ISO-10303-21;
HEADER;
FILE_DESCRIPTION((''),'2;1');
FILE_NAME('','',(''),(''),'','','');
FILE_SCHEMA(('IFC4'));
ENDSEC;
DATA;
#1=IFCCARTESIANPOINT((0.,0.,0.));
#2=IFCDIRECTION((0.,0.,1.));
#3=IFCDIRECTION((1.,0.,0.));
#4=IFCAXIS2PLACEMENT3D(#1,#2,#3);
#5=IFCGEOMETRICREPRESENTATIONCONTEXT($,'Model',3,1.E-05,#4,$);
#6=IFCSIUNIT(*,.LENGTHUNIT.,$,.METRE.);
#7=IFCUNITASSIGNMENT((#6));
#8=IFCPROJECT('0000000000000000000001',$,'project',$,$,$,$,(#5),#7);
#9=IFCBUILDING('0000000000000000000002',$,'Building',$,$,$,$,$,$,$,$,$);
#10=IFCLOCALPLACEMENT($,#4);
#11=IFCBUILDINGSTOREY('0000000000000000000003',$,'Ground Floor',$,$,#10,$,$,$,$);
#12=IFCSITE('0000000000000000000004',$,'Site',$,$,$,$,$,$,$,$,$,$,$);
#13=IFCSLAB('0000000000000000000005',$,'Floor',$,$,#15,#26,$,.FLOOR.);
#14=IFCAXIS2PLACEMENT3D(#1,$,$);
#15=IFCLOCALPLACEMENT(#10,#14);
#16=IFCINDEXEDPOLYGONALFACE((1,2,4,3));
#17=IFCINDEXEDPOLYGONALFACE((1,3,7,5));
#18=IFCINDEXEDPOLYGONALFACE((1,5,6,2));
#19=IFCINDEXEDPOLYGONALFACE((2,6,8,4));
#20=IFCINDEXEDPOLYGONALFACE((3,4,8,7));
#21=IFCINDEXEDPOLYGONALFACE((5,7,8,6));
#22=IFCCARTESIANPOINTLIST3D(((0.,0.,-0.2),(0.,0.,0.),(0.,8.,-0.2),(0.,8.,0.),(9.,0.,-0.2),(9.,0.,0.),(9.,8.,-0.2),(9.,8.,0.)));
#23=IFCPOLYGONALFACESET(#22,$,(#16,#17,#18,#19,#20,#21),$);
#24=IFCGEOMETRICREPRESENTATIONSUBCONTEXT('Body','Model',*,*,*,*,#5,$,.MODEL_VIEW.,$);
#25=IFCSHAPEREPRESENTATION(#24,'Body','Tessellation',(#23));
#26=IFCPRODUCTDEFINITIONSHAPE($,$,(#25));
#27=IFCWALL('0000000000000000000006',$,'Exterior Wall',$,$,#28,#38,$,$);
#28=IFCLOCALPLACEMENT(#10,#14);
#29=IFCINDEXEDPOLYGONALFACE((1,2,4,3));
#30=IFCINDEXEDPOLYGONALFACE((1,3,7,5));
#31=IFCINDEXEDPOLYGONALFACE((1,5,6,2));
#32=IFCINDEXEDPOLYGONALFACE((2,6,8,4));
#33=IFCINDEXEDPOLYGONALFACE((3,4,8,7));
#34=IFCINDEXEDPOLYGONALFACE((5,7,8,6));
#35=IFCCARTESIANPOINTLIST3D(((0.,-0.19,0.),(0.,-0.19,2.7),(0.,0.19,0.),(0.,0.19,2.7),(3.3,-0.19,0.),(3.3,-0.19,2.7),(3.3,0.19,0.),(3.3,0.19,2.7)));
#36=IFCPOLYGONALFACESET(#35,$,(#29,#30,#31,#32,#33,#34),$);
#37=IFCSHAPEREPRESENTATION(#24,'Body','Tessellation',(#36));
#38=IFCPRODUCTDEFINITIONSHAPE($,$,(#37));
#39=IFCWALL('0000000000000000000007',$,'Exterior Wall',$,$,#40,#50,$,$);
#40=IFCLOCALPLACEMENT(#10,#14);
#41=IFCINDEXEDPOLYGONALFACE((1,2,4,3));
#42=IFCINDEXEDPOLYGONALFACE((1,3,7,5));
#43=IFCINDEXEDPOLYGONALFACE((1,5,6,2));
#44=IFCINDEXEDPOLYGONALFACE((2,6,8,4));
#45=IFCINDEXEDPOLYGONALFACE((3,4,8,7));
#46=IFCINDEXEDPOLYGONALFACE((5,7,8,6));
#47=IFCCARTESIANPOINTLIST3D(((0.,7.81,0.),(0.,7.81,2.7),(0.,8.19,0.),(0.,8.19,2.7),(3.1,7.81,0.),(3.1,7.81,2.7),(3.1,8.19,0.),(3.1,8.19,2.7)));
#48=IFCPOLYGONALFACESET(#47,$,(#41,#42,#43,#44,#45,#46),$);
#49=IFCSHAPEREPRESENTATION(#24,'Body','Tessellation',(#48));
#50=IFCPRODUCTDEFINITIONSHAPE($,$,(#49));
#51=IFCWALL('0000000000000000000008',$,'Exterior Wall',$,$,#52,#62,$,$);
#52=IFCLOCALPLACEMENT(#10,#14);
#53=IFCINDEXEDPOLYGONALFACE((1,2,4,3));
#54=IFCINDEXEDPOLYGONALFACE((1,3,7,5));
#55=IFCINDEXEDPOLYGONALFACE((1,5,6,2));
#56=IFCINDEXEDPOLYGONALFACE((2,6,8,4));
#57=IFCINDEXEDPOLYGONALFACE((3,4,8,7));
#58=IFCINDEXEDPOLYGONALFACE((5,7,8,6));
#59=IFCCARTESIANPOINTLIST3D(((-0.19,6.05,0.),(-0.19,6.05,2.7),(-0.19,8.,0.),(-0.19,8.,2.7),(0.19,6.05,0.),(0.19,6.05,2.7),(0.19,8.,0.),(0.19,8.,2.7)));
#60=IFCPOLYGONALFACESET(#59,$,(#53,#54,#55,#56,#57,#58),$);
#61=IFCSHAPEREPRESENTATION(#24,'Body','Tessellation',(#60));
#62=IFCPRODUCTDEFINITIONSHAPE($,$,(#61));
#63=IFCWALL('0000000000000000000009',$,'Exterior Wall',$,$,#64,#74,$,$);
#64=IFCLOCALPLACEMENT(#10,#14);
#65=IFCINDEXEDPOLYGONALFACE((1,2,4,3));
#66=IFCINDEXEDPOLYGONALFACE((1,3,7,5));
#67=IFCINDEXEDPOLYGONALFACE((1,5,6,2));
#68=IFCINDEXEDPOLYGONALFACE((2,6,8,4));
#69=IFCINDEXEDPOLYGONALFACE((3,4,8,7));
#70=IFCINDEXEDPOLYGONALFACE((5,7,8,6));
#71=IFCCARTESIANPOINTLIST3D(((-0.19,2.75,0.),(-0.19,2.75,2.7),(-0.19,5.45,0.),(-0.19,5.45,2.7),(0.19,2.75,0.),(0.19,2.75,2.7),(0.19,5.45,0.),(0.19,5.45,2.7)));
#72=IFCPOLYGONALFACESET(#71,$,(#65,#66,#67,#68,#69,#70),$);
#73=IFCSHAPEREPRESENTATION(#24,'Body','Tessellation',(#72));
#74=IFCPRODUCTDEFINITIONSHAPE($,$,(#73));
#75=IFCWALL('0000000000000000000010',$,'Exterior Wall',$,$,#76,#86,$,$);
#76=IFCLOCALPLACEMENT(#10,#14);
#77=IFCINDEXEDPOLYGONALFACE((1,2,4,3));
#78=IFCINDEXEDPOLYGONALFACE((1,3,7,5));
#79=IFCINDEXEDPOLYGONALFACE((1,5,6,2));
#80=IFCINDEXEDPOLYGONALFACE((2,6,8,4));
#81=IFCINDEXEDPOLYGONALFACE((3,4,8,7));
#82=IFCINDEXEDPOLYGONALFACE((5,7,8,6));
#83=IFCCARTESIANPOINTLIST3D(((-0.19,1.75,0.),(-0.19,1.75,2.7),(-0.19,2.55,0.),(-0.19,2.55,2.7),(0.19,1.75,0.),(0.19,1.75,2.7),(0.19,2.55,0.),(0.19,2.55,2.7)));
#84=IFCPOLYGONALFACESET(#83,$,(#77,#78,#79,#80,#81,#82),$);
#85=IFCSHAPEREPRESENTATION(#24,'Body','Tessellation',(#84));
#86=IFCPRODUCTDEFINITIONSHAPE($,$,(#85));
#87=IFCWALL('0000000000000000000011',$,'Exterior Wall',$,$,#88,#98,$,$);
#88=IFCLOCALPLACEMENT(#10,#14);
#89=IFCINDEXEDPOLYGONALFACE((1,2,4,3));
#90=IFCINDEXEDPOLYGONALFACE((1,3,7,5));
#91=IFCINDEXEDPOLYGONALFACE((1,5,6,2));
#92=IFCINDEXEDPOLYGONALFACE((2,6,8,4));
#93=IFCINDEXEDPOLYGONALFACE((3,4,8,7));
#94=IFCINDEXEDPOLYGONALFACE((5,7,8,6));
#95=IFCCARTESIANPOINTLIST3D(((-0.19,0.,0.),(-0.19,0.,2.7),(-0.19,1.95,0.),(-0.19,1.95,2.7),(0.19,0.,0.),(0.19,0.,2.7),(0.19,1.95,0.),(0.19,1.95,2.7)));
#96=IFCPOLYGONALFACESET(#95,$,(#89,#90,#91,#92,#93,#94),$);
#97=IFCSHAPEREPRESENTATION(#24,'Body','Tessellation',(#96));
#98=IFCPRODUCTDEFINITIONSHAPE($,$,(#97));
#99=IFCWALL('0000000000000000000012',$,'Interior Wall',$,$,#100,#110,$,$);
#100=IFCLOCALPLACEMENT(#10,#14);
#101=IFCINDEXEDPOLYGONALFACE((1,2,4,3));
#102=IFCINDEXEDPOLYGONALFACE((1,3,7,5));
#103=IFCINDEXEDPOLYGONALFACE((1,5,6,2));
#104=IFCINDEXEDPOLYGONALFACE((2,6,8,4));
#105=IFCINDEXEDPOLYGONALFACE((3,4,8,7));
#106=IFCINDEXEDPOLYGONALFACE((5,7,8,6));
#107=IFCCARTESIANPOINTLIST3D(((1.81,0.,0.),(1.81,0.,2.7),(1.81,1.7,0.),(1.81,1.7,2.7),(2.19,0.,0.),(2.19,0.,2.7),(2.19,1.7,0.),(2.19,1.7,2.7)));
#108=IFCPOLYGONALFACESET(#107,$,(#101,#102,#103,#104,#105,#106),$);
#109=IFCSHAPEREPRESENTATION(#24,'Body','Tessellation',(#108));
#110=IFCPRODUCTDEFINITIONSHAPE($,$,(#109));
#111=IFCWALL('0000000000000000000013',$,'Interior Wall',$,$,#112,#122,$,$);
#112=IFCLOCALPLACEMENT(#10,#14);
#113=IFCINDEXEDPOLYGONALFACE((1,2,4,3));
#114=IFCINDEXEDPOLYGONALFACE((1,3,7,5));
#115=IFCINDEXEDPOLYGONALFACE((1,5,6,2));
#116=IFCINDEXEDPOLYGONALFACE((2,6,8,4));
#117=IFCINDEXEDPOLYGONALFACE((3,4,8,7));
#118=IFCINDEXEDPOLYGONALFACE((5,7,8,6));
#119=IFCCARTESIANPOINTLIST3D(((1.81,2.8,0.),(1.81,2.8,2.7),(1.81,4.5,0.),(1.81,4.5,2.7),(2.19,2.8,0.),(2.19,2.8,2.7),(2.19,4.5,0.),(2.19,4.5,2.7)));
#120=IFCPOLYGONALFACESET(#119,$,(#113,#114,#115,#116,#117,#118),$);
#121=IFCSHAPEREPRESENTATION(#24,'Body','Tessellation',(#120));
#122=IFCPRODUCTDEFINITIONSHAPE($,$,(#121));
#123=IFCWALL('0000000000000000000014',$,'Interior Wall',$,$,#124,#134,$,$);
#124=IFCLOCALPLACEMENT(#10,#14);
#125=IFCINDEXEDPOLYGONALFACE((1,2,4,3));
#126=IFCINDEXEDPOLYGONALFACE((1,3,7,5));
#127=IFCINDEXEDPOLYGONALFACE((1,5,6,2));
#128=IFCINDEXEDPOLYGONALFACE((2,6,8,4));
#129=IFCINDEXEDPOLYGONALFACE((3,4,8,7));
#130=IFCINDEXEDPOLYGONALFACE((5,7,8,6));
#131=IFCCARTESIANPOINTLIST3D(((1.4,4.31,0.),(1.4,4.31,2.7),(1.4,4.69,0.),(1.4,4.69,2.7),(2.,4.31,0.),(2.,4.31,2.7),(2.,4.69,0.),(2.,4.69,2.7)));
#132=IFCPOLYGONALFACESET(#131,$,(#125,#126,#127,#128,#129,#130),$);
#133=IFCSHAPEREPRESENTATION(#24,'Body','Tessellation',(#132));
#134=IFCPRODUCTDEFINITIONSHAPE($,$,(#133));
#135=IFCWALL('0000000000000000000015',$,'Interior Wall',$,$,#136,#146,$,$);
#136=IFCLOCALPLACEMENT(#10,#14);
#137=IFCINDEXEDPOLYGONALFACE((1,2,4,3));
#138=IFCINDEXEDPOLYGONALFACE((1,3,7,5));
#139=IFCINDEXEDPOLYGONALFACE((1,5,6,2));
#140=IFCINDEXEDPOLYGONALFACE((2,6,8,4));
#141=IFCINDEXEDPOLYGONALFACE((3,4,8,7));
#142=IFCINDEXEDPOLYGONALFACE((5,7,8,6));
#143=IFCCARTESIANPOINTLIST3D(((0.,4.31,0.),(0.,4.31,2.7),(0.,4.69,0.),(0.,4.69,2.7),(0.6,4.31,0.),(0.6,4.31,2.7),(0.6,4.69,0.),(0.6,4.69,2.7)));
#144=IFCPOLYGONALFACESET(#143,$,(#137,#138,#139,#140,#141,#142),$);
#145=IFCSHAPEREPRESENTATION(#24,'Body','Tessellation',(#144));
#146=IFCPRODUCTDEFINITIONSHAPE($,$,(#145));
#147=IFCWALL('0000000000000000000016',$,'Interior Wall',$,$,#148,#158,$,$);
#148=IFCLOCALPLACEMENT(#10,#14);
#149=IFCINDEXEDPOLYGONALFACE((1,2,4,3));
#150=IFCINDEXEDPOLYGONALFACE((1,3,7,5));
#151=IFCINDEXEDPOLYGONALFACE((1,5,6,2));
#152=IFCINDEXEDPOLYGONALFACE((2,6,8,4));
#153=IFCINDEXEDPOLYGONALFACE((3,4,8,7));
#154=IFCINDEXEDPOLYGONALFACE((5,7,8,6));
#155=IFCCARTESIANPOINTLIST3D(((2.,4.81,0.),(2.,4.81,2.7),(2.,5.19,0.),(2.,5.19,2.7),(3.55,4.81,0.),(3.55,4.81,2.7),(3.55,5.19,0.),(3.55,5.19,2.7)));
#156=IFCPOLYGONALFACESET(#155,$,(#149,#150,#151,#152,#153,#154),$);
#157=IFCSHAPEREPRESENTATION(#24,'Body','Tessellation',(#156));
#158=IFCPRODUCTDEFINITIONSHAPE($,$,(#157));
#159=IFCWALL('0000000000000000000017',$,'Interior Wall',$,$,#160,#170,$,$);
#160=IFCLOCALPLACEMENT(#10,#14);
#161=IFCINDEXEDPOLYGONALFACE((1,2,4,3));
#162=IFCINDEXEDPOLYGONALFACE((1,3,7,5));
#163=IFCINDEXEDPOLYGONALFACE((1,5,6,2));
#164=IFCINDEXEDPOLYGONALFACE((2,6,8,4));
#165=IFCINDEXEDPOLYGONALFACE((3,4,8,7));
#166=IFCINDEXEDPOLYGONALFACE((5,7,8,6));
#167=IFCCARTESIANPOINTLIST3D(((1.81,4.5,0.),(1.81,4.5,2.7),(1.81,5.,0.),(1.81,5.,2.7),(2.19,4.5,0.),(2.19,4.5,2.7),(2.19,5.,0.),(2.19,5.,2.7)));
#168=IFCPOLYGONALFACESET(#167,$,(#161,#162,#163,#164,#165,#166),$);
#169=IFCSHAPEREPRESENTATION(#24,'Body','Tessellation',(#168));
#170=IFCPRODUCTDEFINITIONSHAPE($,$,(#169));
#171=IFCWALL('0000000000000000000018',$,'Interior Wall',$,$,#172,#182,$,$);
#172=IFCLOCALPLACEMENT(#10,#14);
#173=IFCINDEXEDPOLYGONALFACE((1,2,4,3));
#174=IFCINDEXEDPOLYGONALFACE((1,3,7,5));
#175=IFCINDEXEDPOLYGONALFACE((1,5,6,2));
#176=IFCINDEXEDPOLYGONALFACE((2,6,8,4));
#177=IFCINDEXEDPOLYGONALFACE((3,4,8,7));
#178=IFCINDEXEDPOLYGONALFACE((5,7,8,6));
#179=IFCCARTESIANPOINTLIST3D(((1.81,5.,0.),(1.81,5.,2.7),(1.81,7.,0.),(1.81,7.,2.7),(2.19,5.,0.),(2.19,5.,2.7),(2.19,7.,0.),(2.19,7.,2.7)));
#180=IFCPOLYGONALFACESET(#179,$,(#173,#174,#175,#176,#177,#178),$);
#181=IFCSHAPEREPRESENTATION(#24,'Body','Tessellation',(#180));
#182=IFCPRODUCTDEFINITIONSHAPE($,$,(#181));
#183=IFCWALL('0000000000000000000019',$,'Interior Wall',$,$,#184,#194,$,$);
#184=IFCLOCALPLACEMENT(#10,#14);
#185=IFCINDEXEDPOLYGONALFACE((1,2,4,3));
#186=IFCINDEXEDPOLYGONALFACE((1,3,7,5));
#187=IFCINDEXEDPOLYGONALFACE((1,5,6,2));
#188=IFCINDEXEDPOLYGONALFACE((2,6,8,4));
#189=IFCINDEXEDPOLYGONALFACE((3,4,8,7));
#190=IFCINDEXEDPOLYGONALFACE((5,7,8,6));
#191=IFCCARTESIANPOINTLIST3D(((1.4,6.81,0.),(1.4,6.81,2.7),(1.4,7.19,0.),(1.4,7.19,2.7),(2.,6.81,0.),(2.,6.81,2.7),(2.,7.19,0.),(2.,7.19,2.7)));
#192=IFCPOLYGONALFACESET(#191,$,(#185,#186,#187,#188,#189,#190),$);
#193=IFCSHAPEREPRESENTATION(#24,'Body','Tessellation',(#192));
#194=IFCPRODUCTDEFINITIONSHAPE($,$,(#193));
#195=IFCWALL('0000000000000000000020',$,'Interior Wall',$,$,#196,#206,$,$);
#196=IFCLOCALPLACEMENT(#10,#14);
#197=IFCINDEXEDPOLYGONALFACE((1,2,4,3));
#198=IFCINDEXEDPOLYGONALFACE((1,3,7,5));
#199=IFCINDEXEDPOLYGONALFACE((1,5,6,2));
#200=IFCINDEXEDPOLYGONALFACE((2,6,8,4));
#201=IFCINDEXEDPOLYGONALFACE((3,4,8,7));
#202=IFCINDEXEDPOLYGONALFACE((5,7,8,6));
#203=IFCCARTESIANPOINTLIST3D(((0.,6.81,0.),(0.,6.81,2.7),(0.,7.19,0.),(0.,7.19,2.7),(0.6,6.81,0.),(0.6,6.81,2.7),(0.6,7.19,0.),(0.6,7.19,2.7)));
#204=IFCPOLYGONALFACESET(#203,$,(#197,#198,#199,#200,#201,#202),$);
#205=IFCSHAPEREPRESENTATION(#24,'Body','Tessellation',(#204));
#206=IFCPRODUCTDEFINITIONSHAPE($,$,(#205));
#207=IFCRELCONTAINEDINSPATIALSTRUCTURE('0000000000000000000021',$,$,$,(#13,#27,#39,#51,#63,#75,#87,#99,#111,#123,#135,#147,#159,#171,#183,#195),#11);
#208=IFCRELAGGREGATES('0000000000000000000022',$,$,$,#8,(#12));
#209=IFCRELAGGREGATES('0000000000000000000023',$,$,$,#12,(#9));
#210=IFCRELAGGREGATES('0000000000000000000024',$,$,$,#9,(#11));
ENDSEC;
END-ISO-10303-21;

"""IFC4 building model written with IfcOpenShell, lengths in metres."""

from ifc_helpers import new_model, si_unit, frame, origin_with_axes, place, context, subcontext, project, spatial, indexed_curve, outline, extrude, element, save


model = new_model("IFC4")

# Units and contexts
model_context = context("Model", 3, precision=1e-05, world=origin_with_axes())
body_context = subcontext(model_context, "Body", "Model", "MODEL_VIEW")
ifc_project = project(units=[si_unit("LENGTHUNIT", "METRE")], contexts=[model_context])

# Site, building, storey
site = spatial("IfcSite", under=ifc_project, Name="Site")
building = spatial("IfcBuilding", under=site, Name="Building")
storey_placement = place(None, origin_with_axes())
storey = spatial("IfcBuildingStorey", under=building, at=storey_placement, Name="Ground Floor")

# Slab
slab_placement = place(storey_placement, frame((0.0, 0.0, -0.2), z_axis=(0.0, 0.0, 1.0), x_axis=(1.0, 0.0, 0.0)))
element("IfcSlab", 1, at=slab_placement, inside=storey, Name="Floor", PredefinedType="FLOOR", context=body_context, shape_type="SweptSolid", body=[
    extrude(outline(indexed_curve([(0.0, 0.0), (9.0, 0.0), (9.0, 8.0), (0.0, 8.0)])), None, (0.0, 0.0, 1.0), 0.2),
])

# Walls
wall_1_placement = place(storey_placement, origin_with_axes())
element("IfcWall", 2, at=wall_1_placement, inside=storey, Name="Exterior Wall", context=body_context, shape_type="SweptSolid", body=[
    extrude(outline(indexed_curve([(0.0, 0.0), (0.0, 0.38), (3.3, 0.38), (3.3, 0.0), (0.0, 0.0)], self_intersect=False)), frame((0.0, -0.19, 0.0), z_axis=(0.0, 0.0, 1.0), x_axis=(1.0, 0.0, 0.0)), (0.0, 0.0, 1.0), 2.7),
])
wall_2_placement = place(storey_placement, frame((3.1, 8.0, 0.0), z_axis=(0.0, 0.0, 1.0), x_axis=(-1.0, 0.0, 0.0)))
element("IfcWall", 3, at=wall_2_placement, inside=storey, Name="Exterior Wall", context=body_context, shape_type="SweptSolid", body=[
    extrude(outline(indexed_curve([(0.0, 0.0), (0.0, 0.38), (3.1, 0.38), (3.1, 0.0), (0.0, 0.0)], self_intersect=False)), frame((0.0, -0.19, 0.0), z_axis=(0.0, 0.0, 1.0), x_axis=(1.0, 0.0, 0.0)), (0.0, 0.0, 1.0), 2.7),
])
wall_3_placement = place(storey_placement, frame((0.0, 8.0, 0.0), z_axis=(0.0, 0.0, 1.0), x_axis=(0.0, -1.0, 0.0)))
element("IfcWall", 4, at=wall_3_placement, inside=storey, Name="Exterior Wall", context=body_context, shape_type="SweptSolid", body=[
    extrude(outline(indexed_curve([(0.0, 0.0), (0.0, 0.38), (1.95, 0.38), (1.95, 0.0), (0.0, 0.0)], self_intersect=False)), frame((0.0, -0.19, 0.0), z_axis=(0.0, 0.0, 1.0), x_axis=(1.0, 0.0, 0.0)), (0.0, 0.0, 1.0), 2.7),
])
wall_4_placement = place(storey_placement, frame((0.0, 5.45, 0.0), z_axis=(0.0, 0.0, 1.0), x_axis=(0.0, -1.0, 0.0)))
element("IfcWall", 5, at=wall_4_placement, inside=storey, Name="Exterior Wall", context=body_context, shape_type="SweptSolid", body=[
    extrude(outline(indexed_curve([(0.0, 0.0), (0.0, 0.38), (2.7, 0.38), (2.7, 0.0), (0.0, 0.0)], self_intersect=False)), frame((0.0, -0.19, 0.0), z_axis=(0.0, 0.0, 1.0), x_axis=(1.0, 0.0, 0.0)), (0.0, 0.0, 1.0), 2.7),
])
wall_5_placement = place(storey_placement, frame((0.0, 1.75, 0.0), z_axis=(0.0, 0.0, 1.0), x_axis=(0.0, 1.0, 0.0)))
element("IfcWall", 6, at=wall_5_placement, inside=storey, Name="Exterior Wall", context=body_context, shape_type="SweptSolid", body=[
    extrude(outline(indexed_curve([(0.0, 0.0), (0.0, 0.38), (0.8, 0.38), (0.8, 0.0), (0.0, 0.0)], self_intersect=False)), frame((0.0, -0.19, 0.0), z_axis=(0.0, 0.0, 1.0), x_axis=(1.0, 0.0, 0.0)), (0.0, 0.0, 1.0), 2.7),
])
wall_6_placement = place(storey_placement, frame((0.0, 1.95, 0.0), z_axis=(0.0, 0.0, 1.0), x_axis=(0.0, -1.0, 0.0)))
element("IfcWall", 7, at=wall_6_placement, inside=storey, Name="Exterior Wall", context=body_context, shape_type="SweptSolid", body=[
    extrude(outline(indexed_curve([(0.0, 0.0), (0.0, 0.38), (1.95, 0.38), (1.95, 0.0), (0.0, 0.0)], self_intersect=False)), frame((0.0, -0.19, 0.0), z_axis=(0.0, 0.0, 1.0), x_axis=(1.0, 0.0, 0.0)), (0.0, 0.0, 1.0), 2.7),
])
wall_7_placement = place(storey_placement, frame((2.0, 0.0, 0.0), z_axis=(0.0, 0.0, 1.0), x_axis=(0.0, 1.0, 0.0)))
element("IfcWall", 8, at=wall_7_placement, inside=storey, Name="Interior Wall", context=body_context, shape_type="SweptSolid", body=[
    extrude(outline(indexed_curve([(0.0, 0.0), (0.0, 0.38), (1.7, 0.38), (1.7, 0.0), (0.0, 0.0)], self_intersect=False)), frame((0.0, -0.19, 0.0), z_axis=(0.0, 0.0, 1.0), x_axis=(1.0, 0.0, 0.0)), (0.0, 0.0, 1.0), 2.7),
])
wall_8_placement = place(storey_placement, frame((2.0, 2.8, 0.0), z_axis=(0.0, 0.0, 1.0), x_axis=(0.0, 1.0, 0.0)))
element("IfcWall", 9, at=wall_8_placement, inside=storey, Name="Interior Wall", context=body_context, shape_type="SweptSolid", body=[
    extrude(outline(indexed_curve([(0.0, 0.0), (0.0, 0.38), (1.7, 0.38), (1.7, 0.0), (0.0, 0.0)], self_intersect=False)), frame((0.0, -0.19, 0.0), z_axis=(0.0, 0.0, 1.0), x_axis=(1.0, 0.0, 0.0)), (0.0, 0.0, 1.0), 2.7),
])
for number, where, z_axis, x_axis, name in (
    (10, (2.0, 4.5, 0.0), (0.0, 0.0, 1.0), (-1.0, 0.0, 0.0), "Interior Wall"),
    (11, (0.6, 4.5, 0.0), (0.0, 0.0, 1.0), (-1.0, 0.0, 0.0), "Interior Wall"),
):
    element("IfcWall", number, at=place(storey_placement, frame(where, z_axis=z_axis, x_axis=x_axis)), inside=storey, Name=name, context=body_context, shape_type="SweptSolid", body=[
        extrude(outline(indexed_curve([(0.0, 0.0), (0.0, 0.38), (0.6, 0.38), (0.6, 0.0), (0.0, 0.0)], self_intersect=False)), frame((0.0, -0.19, 0.0), z_axis=(0.0, 0.0, 1.0), x_axis=(1.0, 0.0, 0.0)), (0.0, 0.0, 1.0), 2.7),
    ])
wall_9_placement = place(storey_placement, frame((3.55, 5.0, 0.0), z_axis=(0.0, 0.0, 1.0), x_axis=(-1.0, 0.0, 0.0)))
element("IfcWall", 12, at=wall_9_placement, inside=storey, Name="Interior Wall", context=body_context, shape_type="SweptSolid", body=[
    extrude(outline(indexed_curve([(0.0, 0.0), (0.0, 0.38), (1.55, 0.38), (1.55, 0.0), (0.0, 0.0)], self_intersect=False)), frame((0.0, -0.19, 0.0), z_axis=(0.0, 0.0, 1.0), x_axis=(1.0, 0.0, 0.0)), (0.0, 0.0, 1.0), 2.7),
])
wall_10_placement = place(storey_placement, frame((2.0, 5.0, 0.0), z_axis=(0.0, 0.0, 1.0), x_axis=(0.0, -1.0, 0.0)))
element("IfcWall", 13, at=wall_10_placement, inside=storey, Name="Interior Wall", context=body_context, shape_type="SweptSolid", body=[
    extrude(outline(indexed_curve([(0.0, 0.0), (0.0, 0.38), (0.5, 0.38), (0.5, 0.0), (0.0, 0.0)], self_intersect=False)), frame((0.0, -0.19, 0.0), z_axis=(0.0, 0.0, 1.0), x_axis=(1.0, 0.0, 0.0)), (0.0, 0.0, 1.0), 2.7),
])
wall_11_placement = place(storey_placement, frame((2.0, 5.0, 0.0), z_axis=(0.0, 0.0, 1.0), x_axis=(0.0, 1.0, 0.0)))
element("IfcWall", 14, at=wall_11_placement, inside=storey, Name="Interior Wall", context=body_context, shape_type="SweptSolid", body=[
    extrude(outline(indexed_curve([(0.0, 0.0), (0.0, 0.38), (2.0, 0.38), (2.0, 0.0), (0.0, 0.0)], self_intersect=False)), frame((0.0, -0.19, 0.0), z_axis=(0.0, 0.0, 1.0), x_axis=(1.0, 0.0, 0.0)), (0.0, 0.0, 1.0), 2.7),
])
for number, where, z_axis, x_axis, name in (
    (15, (2.0, 7.0, 0.0), (0.0, 0.0, 1.0), (-1.0, 0.0, 0.0), "Interior Wall"),
    (16, (0.6, 7.0, 0.0), (0.0, 0.0, 1.0), (-1.0, 0.0, 0.0), "Interior Wall"),
):
    element("IfcWall", number, at=place(storey_placement, frame(where, z_axis=z_axis, x_axis=x_axis)), inside=storey, Name=name, context=body_context, shape_type="SweptSolid", body=[
        extrude(outline(indexed_curve([(0.0, 0.0), (0.0, 0.38), (0.6, 0.38), (0.6, 0.0), (0.0, 0.0)], self_intersect=False)), frame((0.0, -0.19, 0.0), z_axis=(0.0, 0.0, 1.0), x_axis=(1.0, 0.0, 0.0)), (0.0, 0.0, 1.0), 2.7),
    ])

save(model, "model.ifc")
